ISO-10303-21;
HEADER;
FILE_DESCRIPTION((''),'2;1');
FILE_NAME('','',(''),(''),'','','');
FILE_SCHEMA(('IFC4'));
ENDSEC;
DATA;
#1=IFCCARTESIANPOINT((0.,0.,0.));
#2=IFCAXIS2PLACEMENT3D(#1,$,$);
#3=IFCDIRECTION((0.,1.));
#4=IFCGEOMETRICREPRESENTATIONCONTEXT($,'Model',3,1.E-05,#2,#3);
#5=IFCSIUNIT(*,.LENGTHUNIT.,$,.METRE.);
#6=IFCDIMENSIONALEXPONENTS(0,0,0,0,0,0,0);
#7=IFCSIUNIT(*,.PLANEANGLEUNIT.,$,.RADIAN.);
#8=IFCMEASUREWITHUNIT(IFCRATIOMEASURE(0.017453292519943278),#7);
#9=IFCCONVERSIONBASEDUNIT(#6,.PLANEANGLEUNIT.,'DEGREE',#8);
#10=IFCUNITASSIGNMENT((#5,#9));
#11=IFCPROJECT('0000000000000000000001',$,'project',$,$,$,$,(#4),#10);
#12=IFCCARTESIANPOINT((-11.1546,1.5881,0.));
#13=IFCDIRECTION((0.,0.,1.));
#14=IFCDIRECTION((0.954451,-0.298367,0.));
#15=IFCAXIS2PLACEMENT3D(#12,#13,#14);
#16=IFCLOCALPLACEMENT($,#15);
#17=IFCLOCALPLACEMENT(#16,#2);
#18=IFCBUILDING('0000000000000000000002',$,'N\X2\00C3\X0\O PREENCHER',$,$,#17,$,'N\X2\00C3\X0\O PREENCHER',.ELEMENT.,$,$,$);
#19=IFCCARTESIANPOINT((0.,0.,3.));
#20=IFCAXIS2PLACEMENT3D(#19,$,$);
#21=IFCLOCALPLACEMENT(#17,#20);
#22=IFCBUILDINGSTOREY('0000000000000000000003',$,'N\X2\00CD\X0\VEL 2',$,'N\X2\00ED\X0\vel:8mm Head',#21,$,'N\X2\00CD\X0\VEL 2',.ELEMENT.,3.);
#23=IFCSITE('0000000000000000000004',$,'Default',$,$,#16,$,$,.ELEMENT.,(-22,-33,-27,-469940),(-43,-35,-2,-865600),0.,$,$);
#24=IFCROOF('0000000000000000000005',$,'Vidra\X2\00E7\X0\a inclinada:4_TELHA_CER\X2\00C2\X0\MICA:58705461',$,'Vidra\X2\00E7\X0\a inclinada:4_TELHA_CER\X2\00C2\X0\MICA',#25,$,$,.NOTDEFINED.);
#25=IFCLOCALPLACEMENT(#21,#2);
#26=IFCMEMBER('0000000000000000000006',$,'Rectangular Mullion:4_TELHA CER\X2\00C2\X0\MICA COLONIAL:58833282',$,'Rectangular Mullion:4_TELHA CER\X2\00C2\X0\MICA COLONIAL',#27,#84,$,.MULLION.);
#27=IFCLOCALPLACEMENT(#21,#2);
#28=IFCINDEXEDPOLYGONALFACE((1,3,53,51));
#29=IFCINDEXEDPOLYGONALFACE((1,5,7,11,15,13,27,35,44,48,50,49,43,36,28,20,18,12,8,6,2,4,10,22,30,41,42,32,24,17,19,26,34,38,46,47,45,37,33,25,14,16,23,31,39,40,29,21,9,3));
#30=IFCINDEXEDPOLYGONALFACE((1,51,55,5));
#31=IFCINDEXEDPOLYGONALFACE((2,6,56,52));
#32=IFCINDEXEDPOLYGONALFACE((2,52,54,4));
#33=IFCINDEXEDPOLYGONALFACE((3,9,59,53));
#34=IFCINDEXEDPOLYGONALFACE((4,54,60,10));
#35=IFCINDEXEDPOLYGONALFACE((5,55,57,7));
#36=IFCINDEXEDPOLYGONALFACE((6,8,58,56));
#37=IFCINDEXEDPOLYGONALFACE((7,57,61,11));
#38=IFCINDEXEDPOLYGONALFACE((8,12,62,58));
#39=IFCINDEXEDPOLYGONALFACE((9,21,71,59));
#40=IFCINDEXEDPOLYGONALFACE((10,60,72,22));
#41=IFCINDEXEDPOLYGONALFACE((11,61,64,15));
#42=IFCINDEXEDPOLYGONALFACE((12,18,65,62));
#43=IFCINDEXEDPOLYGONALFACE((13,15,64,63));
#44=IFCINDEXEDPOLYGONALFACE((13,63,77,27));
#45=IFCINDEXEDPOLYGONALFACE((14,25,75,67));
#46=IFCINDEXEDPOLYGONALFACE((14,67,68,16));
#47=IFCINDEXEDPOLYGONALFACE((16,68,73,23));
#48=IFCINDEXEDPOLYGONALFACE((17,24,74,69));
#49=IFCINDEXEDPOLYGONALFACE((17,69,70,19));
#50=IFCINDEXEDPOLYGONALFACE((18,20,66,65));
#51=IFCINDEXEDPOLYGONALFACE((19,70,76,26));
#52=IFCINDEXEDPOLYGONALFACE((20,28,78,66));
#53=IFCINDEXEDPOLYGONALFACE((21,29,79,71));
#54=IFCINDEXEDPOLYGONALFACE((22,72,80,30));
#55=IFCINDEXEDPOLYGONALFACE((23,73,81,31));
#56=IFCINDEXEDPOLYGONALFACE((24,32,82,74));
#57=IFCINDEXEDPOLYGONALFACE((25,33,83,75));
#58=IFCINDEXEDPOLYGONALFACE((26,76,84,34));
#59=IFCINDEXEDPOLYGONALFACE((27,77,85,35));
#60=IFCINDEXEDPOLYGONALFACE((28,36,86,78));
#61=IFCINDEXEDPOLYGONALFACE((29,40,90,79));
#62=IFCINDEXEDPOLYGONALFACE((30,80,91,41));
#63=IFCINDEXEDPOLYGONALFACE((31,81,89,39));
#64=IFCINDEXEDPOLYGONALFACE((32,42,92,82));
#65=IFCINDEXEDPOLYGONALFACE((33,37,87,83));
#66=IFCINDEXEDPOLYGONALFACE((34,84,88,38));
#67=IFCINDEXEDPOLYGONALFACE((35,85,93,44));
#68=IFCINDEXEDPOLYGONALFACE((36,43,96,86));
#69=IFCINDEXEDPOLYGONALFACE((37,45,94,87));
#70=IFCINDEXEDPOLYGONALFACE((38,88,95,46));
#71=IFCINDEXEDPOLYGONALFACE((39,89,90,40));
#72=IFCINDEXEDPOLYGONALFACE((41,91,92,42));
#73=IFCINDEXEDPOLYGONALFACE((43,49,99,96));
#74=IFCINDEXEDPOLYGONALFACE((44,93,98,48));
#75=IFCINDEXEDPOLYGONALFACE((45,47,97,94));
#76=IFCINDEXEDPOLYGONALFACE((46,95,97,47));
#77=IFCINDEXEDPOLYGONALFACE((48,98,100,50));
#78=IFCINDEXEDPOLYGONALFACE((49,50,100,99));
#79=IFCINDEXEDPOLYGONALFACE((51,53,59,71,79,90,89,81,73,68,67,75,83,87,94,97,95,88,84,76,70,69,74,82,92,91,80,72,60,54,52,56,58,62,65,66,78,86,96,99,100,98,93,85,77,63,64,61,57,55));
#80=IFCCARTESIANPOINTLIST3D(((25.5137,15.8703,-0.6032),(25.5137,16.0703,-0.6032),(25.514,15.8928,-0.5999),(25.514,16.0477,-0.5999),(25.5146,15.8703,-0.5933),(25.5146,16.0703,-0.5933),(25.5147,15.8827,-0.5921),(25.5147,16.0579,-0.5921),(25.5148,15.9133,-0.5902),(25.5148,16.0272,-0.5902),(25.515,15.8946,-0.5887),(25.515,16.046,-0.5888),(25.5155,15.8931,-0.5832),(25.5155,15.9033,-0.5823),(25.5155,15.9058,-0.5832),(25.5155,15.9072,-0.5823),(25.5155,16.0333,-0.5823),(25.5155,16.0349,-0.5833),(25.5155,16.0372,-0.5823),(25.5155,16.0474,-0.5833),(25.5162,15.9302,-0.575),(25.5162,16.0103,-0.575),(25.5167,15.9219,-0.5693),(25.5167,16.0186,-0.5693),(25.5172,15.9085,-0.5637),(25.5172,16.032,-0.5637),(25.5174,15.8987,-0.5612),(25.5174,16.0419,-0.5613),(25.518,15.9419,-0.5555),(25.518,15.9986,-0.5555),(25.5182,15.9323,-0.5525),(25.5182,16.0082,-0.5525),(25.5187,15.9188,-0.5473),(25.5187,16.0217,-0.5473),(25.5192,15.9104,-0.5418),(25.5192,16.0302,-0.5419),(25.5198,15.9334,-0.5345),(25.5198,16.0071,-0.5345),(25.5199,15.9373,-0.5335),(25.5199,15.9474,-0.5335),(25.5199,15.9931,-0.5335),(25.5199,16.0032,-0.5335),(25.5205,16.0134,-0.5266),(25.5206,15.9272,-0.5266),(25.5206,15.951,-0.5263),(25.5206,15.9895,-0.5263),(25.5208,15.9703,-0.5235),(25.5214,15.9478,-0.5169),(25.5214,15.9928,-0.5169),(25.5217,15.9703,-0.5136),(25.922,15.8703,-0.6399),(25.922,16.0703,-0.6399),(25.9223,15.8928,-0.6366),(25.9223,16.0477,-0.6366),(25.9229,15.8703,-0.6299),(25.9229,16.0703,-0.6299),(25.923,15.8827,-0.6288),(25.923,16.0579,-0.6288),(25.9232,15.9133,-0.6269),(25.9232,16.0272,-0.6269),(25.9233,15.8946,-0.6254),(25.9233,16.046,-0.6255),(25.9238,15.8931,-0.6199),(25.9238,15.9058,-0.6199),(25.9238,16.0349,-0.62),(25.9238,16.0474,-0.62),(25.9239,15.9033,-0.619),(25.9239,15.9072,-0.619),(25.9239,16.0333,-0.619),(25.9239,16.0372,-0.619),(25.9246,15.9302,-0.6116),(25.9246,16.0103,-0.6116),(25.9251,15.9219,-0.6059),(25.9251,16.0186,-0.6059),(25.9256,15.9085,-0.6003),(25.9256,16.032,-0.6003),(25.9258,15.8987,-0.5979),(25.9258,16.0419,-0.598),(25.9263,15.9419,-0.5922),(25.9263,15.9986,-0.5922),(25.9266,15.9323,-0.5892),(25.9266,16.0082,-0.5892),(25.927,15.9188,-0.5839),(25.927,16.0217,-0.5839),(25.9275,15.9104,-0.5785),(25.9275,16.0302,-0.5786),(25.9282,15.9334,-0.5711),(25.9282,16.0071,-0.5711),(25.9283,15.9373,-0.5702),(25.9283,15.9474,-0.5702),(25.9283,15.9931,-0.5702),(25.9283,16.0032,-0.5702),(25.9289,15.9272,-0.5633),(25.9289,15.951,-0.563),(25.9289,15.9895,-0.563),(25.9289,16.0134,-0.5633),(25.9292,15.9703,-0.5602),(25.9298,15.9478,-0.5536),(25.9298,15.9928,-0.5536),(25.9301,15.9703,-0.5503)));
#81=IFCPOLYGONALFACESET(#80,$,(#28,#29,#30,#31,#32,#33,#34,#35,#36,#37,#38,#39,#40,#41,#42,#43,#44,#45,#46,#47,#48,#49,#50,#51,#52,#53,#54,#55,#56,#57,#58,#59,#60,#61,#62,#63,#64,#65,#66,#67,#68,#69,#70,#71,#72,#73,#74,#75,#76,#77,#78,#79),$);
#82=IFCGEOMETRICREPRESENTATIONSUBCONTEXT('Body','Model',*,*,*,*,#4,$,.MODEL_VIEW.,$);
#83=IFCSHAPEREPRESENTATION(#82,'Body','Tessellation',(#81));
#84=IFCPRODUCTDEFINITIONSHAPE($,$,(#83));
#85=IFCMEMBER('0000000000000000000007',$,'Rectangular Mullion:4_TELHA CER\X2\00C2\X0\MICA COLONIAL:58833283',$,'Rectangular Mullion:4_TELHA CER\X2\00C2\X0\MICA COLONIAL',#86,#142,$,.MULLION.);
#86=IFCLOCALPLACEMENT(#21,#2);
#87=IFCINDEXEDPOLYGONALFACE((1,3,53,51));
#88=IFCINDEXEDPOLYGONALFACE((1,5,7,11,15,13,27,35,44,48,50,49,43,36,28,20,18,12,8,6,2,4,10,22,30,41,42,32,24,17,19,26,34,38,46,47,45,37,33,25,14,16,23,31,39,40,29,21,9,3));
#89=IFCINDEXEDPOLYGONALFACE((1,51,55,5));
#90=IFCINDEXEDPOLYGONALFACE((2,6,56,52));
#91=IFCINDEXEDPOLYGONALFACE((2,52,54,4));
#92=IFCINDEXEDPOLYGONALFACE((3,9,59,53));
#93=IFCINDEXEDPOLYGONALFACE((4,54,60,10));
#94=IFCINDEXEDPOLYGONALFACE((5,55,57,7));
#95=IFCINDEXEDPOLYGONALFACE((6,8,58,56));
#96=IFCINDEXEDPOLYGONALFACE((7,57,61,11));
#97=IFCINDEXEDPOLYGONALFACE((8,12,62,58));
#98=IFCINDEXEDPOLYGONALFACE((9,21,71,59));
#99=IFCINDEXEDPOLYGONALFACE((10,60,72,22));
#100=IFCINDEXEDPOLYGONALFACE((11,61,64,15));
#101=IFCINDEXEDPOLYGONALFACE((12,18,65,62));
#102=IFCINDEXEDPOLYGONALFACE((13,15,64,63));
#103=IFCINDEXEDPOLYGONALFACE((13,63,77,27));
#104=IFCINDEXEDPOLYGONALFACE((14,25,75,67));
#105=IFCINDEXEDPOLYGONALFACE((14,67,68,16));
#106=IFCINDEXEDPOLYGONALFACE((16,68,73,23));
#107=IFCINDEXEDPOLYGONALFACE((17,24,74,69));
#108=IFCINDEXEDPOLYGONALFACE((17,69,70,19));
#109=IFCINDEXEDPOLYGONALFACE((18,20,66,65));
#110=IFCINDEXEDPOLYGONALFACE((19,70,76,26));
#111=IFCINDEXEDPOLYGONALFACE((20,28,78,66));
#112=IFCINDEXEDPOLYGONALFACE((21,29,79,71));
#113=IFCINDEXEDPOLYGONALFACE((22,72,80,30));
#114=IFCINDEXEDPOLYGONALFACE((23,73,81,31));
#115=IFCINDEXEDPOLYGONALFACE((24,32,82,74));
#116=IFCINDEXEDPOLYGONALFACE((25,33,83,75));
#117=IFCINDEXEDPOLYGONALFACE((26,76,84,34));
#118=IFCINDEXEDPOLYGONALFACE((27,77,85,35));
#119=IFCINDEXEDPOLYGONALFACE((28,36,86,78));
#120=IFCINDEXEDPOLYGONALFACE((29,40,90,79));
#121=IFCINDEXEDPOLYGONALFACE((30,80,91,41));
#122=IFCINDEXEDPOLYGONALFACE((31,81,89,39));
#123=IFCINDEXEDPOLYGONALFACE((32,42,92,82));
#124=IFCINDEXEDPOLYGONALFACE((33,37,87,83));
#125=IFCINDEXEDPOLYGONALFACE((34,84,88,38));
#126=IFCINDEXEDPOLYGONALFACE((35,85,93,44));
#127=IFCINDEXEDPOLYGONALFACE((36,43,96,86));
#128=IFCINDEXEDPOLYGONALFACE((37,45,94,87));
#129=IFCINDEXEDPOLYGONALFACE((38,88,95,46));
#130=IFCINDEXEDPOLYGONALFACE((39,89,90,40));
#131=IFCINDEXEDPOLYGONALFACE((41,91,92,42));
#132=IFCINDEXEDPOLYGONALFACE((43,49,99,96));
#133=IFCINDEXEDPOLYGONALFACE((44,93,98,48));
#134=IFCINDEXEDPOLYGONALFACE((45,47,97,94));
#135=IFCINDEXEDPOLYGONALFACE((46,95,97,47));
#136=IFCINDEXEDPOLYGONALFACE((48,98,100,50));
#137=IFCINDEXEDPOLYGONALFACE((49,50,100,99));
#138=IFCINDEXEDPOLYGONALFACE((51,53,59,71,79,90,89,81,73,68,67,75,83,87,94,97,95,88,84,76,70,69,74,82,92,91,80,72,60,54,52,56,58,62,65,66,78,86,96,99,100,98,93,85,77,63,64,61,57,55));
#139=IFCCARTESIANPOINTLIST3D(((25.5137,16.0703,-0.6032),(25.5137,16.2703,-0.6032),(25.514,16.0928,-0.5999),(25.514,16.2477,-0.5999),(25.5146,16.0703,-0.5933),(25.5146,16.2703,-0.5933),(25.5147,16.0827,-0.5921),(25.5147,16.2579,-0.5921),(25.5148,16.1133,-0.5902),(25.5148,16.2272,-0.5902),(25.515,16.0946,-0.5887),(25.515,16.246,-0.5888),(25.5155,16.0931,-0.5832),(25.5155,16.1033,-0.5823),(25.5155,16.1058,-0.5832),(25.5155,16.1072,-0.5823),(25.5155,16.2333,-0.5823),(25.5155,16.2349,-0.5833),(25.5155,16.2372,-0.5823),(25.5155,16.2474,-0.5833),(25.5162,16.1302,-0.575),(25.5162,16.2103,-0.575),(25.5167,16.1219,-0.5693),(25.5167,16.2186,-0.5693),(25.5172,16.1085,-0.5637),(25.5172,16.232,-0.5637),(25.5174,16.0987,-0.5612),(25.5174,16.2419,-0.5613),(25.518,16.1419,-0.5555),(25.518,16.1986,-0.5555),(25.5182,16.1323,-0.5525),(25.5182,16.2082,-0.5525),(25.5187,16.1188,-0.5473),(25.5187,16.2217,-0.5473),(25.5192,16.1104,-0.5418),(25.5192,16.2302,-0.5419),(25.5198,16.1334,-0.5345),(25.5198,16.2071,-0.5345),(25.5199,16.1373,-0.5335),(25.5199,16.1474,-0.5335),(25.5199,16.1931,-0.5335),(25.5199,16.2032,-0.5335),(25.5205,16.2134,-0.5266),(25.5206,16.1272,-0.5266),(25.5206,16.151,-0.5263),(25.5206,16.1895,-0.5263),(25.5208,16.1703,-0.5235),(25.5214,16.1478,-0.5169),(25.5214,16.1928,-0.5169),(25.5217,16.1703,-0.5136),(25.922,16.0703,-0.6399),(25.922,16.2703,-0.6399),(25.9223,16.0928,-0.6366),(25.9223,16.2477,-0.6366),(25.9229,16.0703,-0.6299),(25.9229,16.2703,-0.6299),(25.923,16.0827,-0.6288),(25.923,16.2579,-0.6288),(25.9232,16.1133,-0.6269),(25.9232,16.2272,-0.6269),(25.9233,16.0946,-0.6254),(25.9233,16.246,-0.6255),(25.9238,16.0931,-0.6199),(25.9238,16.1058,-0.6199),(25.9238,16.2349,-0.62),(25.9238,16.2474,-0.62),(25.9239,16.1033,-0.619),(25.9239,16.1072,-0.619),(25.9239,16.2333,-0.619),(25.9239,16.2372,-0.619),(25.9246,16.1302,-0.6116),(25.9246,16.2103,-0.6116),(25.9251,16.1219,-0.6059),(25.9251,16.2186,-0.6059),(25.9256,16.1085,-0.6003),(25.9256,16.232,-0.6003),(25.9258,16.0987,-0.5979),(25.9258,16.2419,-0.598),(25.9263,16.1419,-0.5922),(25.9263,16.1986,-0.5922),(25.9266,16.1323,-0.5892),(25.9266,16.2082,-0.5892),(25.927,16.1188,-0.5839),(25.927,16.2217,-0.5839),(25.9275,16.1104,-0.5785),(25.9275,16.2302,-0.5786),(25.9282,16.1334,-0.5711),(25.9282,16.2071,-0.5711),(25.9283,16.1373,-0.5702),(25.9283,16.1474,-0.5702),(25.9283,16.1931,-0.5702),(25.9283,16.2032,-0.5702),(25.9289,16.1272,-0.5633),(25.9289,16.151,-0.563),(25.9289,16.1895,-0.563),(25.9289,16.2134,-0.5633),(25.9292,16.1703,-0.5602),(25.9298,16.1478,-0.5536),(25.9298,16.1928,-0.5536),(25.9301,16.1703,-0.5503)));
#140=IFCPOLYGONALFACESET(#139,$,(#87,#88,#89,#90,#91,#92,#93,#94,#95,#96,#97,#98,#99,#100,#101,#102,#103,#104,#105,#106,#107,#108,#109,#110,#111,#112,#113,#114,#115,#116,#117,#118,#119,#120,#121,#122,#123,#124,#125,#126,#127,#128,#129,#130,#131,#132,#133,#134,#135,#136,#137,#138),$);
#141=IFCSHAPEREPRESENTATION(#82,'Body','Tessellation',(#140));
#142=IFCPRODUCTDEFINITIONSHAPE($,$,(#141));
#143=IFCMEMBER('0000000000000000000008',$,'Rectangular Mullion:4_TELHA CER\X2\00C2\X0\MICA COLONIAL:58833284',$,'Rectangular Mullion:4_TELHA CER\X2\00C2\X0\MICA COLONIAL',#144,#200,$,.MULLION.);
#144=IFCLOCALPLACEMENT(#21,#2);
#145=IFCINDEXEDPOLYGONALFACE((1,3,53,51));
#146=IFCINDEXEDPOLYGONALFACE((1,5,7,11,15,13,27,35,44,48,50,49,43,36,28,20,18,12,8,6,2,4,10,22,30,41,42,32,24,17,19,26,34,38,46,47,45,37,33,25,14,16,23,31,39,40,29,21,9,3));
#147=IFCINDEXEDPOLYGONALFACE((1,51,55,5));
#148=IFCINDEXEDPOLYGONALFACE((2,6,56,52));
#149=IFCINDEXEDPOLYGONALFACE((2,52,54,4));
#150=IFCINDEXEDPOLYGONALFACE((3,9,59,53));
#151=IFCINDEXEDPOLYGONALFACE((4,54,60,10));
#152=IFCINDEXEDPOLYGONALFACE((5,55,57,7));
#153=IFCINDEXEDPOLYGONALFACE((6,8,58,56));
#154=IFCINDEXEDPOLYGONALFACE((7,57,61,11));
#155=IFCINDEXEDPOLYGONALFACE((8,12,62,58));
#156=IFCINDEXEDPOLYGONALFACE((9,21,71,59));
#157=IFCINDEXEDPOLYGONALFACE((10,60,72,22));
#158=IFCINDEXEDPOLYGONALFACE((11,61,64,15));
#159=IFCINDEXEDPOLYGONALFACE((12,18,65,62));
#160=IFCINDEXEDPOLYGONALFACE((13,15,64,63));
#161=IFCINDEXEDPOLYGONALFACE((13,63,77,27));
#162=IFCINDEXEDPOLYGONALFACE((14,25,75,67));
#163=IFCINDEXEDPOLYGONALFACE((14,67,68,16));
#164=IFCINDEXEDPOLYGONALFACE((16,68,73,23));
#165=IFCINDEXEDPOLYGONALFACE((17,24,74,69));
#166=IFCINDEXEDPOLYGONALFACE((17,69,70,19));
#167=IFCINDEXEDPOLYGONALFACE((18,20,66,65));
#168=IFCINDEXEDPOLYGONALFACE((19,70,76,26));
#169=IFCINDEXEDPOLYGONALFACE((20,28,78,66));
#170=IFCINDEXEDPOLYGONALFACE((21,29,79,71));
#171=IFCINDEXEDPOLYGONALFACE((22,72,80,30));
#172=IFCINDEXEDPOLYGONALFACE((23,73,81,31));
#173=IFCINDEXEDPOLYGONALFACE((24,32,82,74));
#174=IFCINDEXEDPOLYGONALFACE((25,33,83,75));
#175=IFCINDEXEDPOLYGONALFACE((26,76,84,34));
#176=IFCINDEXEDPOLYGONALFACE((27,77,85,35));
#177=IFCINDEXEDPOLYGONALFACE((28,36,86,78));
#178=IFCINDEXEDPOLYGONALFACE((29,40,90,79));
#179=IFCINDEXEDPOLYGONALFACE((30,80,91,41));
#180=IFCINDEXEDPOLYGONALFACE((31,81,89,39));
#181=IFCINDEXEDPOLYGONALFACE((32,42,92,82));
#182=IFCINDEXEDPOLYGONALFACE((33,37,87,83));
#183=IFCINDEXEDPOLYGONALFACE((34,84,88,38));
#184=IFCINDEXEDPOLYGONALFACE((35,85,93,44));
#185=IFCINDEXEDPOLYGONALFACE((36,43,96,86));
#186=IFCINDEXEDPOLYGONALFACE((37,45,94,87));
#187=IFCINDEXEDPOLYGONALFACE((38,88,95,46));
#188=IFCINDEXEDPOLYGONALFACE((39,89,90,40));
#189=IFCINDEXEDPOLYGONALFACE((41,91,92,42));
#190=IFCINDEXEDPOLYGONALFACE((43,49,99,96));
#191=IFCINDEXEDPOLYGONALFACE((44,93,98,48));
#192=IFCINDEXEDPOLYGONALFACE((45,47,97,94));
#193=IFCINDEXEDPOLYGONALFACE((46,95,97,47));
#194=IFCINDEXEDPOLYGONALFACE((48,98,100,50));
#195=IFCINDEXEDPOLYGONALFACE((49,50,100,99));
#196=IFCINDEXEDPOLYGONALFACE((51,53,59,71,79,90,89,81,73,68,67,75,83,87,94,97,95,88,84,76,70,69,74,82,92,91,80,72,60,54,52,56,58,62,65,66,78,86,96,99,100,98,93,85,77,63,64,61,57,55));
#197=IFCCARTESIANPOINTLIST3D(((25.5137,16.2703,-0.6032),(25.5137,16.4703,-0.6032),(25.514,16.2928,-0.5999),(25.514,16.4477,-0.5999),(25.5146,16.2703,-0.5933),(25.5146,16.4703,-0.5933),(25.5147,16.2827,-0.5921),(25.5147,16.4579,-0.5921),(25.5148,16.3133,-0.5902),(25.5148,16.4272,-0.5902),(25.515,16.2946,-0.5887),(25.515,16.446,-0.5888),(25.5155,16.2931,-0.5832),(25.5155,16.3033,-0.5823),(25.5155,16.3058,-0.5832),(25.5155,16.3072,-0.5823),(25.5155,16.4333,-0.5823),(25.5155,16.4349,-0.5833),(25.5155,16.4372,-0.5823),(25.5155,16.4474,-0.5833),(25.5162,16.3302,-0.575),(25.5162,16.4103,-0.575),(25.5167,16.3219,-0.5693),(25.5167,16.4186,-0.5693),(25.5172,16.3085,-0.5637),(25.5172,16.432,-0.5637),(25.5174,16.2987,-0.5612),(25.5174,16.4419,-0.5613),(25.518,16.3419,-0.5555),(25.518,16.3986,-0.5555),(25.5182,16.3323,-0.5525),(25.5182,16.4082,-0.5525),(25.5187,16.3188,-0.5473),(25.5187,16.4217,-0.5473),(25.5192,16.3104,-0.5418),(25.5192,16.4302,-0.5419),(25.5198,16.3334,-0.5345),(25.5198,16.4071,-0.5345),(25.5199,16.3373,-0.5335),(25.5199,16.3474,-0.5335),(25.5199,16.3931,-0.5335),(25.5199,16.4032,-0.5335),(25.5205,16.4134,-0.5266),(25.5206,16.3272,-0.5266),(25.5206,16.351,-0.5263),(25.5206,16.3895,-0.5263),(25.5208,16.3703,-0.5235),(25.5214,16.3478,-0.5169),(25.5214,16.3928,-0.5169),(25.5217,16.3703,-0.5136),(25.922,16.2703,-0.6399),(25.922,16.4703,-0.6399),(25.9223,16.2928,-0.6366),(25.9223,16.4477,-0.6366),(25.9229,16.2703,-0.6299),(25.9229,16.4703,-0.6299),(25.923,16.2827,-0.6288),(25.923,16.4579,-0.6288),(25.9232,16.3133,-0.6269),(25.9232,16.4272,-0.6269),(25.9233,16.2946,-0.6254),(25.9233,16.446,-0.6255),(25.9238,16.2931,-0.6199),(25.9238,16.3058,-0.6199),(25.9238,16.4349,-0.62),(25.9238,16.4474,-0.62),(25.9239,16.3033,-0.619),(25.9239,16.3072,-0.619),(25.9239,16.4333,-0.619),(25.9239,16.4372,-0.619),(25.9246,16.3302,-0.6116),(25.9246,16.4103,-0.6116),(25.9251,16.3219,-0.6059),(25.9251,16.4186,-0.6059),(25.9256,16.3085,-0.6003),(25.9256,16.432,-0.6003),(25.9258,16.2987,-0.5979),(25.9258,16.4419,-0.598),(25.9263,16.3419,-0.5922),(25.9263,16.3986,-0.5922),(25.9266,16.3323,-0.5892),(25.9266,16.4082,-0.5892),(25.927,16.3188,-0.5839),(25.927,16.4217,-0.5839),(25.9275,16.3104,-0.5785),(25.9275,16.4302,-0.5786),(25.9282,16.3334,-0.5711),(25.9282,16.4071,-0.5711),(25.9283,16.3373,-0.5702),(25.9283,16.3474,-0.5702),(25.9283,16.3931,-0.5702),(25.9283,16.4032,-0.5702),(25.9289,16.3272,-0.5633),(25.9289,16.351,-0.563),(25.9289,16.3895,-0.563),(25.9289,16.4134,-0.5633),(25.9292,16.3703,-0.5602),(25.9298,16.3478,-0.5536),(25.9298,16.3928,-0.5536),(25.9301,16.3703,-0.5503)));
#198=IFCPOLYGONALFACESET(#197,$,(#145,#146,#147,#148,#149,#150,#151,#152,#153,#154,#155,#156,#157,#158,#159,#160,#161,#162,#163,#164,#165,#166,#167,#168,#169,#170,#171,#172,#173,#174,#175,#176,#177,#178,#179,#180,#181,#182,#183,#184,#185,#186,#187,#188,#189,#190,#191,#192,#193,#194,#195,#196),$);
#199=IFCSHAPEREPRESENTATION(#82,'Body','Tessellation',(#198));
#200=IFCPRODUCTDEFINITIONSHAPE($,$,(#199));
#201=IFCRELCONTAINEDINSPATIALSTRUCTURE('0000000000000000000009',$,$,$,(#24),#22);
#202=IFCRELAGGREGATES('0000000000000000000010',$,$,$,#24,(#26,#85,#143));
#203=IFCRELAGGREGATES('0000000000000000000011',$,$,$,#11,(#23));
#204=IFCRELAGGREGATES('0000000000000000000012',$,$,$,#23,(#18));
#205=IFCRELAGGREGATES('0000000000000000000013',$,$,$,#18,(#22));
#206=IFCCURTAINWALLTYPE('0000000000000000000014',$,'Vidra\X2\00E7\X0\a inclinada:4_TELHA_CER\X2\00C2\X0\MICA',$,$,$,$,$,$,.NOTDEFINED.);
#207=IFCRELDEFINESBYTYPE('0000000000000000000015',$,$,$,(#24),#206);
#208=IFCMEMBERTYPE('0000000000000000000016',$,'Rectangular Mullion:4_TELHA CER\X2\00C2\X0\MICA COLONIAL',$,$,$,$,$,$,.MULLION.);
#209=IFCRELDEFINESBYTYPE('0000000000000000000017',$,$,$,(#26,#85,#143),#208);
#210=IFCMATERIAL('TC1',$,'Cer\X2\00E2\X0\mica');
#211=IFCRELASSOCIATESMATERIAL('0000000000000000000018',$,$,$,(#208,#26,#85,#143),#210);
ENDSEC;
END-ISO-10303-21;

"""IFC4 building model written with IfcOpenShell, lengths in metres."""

from ifc_helpers import new_model, entity, si_unit, converted_unit, direction, frame, origin, place, context, subcontext, project, spatial, line, arc, indexed_curve, outline, extrude, source, transform, mapped, material, type_object, type_shapes, element, aggregate, save


model = new_model("IFC4")

# Units and contexts
model_context = context("Model", 3, precision=1e-05, world=origin(), true_north=direction((0.0, 1.0)))
body_context = subcontext(model_context, "Body", "Model", "MODEL_VIEW")
ifc_project = project(units=[si_unit("LENGTHUNIT", "METRE"), converted_unit("PLANEANGLEUNIT", "DEGREE", entity("IfcRatioMeasure", 0.017453292519943278), si_unit("PLANEANGLEUNIT", "RADIAN"), dimensions=[0, 0, 0, 0, 0, 0, 0])], contexts=[model_context])

# Site, building, storey
site_placement = place(None, frame((-11.1546, 1.5881, 0.0), z_axis=(0.0, 0.0, 1.0), x_axis=(0.954451, -0.298367, 0.0)))
site = spatial("IfcSite", under=ifc_project, at=site_placement, Name="Default", CompositionType="ELEMENT", RefLatitude=(-22, -33, -27, -469940), RefLongitude=(-43, -35, -2, -865600), RefElevation=0.0)
building_placement = place(site_placement, origin())
building = spatial("IfcBuilding", under=site, at=building_placement, Name="NÃO PREENCHER", LongName="NÃO PREENCHER", CompositionType="ELEMENT")
storey_placement = place(building_placement, frame((0.0, 0.0, 3.0)))
storey = spatial("IfcBuildingStorey", under=building, at=storey_placement, Name="NÍVEL 2", ObjectType="Nível:8mm Head", LongName="NÍVEL 2", CompositionType="ELEMENT", Elevation=3.0)

# Roof, members
curtain_wall_type = type_object("IfcCurtainWallType", Name="Vidraça inclinada:4_TELHA_CERÂMICA", PredefinedType="NOTDEFINED")
roof_placement = place(storey_placement, frame((0.0, 0.0, -3.0)))
roof = element("IfcRoof", 1, at=roof_placement, inside=storey, type_object=curtain_wall_type, Name="Vidraça inclinada:4_TELHA_CERÂMICA:58705461", ObjectType="Vidraça inclinada:4_TELHA_CERÂMICA", PredefinedType="NOTDEFINED")
ifc_material = material(Name="TC1", Category="Cerâmica")
member_type = type_object("IfcMemberType", Name="Rectangular Mullion:4_TELHA CERÂMICA COLONIAL", PredefinedType="MULLION", material=ifc_material)
shared_shape = source(origin(), body_context, "Body", "SweptSolid", [
    extrude(outline(indexed_curve([(-0.029, -0.1), (-0.019, -0.1), (-0.0164, -0.0815), (-0.0089, -0.0645), (-0.0089, -0.0771), (0.061, 0.0), (-0.009, 0.0771), (-0.009, 0.0646), (-0.0165, 0.0816), (-0.019, 0.1), (-0.029, 0.1), (-0.0089, 0.0479), (0.041, 0.0229), (0.041, 0.0329), (0.0131, 0.0425), (-0.008, 0.0631), (-0.008, 0.067), (0.051, 0.0), (-0.008, -0.067), (-0.008, -0.0631), (0.0131, -0.0425), (0.041, -0.0329), (0.041, -0.0229), (-0.0089, -0.0479)], segments=[line(1, 2), arc(2, 3, 4), line(4, 5), arc(5, 6, 7), line(7, 8), arc(8, 9, 10), line(10, 11), arc(11, 12, 13), line(13, 14), arc(14, 15, 16), line(16, 17), arc(17, 18, 19), line(19, 20), arc(20, 21, 22), line(22, 23), arc(23, 24, 1)], self_intersect=False)), frame((0.0, -0.029, -0.41), z_axis=(0.0, 0.0, 1.0), x_axis=(0.0, -1.0, 0.0)), (0.0, 0.0, 1.0), 0.41),
])
type_shapes(member_type, [shared_shape])
member_1_placement = place(roof_placement, frame((25.5137, 15.9703, 2.3968), z_axis=(-0.99599, 0.0, 0.089469), x_axis=(0.0, 1.0, 0.0)))
member_1 = element("IfcMember", 2, at=member_1_placement, type_object=member_type, material=ifc_material, Name="Rectangular Mullion:4_TELHA CERÂMICA COLONIAL:58833282", ObjectType="Rectangular Mullion:4_TELHA CERÂMICA COLONIAL", PredefinedType="MULLION", context=body_context, shape_type="MappedRepresentation", body=[
    mapped(shared_shape, transform((0.0, 0.0, 0.0), scale=1.0)),
])
member_2_placement = place(roof_placement, frame((25.5137, 16.1703, 2.3968), z_axis=(-0.99599, 0.0, 0.089469), x_axis=(0.0, 1.0, 0.0)))
member_2 = element("IfcMember", 3, at=member_2_placement, type_object=member_type, material=ifc_material, Name="Rectangular Mullion:4_TELHA CERÂMICA COLONIAL:58833283", ObjectType="Rectangular Mullion:4_TELHA CERÂMICA COLONIAL", PredefinedType="MULLION", context=body_context, shape_type="MappedRepresentation", body=[
    mapped(shared_shape, transform((0.0, 0.0, 0.0), scale=1.0)),
])
member_3_placement = place(roof_placement, frame((25.5137, 16.3703, 2.3968), z_axis=(-0.99599, 0.0, 0.089469), x_axis=(0.0, 1.0, 0.0)))
member_3 = element("IfcMember", 4, at=member_3_placement, type_object=member_type, material=ifc_material, Name="Rectangular Mullion:4_TELHA CERÂMICA COLONIAL:58833284", ObjectType="Rectangular Mullion:4_TELHA CERÂMICA COLONIAL", PredefinedType="MULLION", context=body_context, shape_type="MappedRepresentation", body=[
    mapped(shared_shape, transform((0.0, 0.0, 0.0), scale=1.0)),
])
aggregate(roof, [member_1, member_2, member_3])

save(model, "model.ifc")
